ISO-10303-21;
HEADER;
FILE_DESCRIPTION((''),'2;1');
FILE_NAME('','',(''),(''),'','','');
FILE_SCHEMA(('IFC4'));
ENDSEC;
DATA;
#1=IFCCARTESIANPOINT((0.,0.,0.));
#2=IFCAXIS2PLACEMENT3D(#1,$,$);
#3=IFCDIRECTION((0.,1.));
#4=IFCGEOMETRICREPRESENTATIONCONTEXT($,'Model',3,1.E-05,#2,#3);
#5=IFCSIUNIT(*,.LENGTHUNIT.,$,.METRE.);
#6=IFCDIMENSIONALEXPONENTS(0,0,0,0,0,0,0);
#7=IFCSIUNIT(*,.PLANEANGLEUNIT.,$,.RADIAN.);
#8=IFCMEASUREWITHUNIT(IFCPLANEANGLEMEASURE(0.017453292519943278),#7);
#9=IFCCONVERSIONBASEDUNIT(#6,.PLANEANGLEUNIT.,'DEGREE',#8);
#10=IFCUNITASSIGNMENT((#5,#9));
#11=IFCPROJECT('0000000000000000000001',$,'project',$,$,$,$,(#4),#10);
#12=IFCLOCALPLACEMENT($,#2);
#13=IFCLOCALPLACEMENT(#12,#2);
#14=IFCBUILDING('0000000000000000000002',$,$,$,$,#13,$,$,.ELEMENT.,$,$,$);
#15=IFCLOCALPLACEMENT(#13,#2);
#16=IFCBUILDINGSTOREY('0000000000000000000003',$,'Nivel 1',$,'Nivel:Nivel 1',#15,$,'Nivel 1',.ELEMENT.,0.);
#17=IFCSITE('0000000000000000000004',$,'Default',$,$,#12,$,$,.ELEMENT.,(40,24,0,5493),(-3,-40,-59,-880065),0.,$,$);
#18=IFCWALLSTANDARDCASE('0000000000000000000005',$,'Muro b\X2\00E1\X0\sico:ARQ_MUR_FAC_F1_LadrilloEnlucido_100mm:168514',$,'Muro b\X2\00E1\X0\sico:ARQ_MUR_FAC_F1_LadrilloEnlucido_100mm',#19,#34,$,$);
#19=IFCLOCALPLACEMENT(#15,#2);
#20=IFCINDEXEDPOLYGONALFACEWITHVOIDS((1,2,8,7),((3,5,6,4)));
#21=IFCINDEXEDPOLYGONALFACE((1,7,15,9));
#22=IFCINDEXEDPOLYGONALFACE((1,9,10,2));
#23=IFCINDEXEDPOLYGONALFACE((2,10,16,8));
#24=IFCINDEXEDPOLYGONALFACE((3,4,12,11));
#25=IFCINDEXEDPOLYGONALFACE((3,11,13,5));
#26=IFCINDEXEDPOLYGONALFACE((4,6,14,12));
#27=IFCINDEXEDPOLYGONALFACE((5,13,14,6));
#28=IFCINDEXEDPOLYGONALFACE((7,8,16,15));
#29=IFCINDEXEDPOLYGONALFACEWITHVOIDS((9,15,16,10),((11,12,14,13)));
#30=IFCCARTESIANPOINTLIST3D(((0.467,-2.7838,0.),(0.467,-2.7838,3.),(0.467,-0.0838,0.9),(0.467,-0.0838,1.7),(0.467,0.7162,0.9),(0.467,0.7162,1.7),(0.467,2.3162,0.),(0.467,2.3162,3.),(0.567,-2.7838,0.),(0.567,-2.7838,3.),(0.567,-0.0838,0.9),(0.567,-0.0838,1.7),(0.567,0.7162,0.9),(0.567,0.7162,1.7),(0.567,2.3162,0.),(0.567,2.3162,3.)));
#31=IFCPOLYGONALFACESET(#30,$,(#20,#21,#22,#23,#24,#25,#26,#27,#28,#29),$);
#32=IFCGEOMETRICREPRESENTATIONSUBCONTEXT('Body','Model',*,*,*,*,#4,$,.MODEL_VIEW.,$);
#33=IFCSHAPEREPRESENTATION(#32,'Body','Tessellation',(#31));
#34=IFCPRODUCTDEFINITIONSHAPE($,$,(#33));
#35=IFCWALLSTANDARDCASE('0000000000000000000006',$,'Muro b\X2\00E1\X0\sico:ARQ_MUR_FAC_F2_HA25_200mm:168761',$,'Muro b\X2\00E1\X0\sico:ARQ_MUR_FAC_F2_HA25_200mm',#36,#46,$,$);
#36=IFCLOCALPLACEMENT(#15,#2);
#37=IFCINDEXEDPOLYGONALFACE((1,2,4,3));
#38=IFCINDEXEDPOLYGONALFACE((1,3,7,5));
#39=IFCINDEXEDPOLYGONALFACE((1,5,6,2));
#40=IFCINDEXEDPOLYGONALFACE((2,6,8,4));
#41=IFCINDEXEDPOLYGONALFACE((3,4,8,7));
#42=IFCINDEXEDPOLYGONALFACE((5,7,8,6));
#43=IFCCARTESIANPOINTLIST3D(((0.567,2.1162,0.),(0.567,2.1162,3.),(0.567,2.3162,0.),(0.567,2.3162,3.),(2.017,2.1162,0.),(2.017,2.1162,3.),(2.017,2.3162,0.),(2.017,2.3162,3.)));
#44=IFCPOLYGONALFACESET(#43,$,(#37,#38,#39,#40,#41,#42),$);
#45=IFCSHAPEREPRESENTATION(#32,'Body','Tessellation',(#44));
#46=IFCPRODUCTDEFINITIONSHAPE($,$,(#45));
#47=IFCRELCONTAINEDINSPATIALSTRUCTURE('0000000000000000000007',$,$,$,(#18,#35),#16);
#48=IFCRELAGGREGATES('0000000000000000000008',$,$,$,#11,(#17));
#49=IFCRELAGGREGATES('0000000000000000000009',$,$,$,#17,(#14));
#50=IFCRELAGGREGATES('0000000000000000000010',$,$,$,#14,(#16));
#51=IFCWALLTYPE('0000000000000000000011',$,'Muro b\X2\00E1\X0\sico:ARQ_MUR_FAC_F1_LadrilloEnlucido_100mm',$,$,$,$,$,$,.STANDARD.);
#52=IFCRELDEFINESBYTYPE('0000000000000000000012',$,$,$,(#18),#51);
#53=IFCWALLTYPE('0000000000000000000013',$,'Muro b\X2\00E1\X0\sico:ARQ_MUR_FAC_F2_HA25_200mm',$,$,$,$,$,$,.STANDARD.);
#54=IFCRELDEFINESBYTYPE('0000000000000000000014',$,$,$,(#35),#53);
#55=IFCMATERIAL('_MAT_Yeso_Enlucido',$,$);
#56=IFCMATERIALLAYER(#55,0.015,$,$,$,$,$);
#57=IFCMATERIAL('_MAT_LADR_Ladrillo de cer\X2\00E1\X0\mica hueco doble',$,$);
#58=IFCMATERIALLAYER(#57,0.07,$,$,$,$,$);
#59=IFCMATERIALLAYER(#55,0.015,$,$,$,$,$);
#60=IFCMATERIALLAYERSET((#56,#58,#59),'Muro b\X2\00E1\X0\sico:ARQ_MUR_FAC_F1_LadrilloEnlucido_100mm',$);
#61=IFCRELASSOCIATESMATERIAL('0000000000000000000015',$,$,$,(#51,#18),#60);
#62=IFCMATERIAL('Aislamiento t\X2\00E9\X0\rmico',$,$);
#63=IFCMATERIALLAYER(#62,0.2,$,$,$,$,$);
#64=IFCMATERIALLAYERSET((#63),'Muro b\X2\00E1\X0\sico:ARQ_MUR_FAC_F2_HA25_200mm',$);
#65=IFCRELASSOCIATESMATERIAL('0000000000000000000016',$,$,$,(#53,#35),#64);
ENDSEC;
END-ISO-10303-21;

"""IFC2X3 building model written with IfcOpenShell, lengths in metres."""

from ifc_helpers import new_model, entity, si_unit, converted_unit, direction, frame, frame_2d, origin, place, context, subcontext, project, spatial, rectangle, extrude, material, layer, layer_set, layer_usage, type_object, element, save


model = new_model("IFC2X3")

# Units and contexts
model_context = context("Model", 3, precision=1e-05, world=origin(), true_north=direction((0.0, 1.0)))
body_context = subcontext(model_context, "Body", "Model", "MODEL_VIEW")
ifc_project = project(units=[si_unit("LENGTHUNIT", "METRE"), converted_unit("PLANEANGLEUNIT", "DEGREE", entity("IfcPlaneAngleMeasure", 0.017453292519943278), si_unit("PLANEANGLEUNIT", "RADIAN"), dimensions=[0, 0, 0, 0, 0, 0, 0])], contexts=[model_context])

# Site, building, storey
site_placement = place(None, origin())
site = spatial("IfcSite", under=ifc_project, at=site_placement, Name="Default", CompositionType="ELEMENT", RefLatitude=(40, 24, 0, 5493), RefLongitude=(-3, -40, -59, -880065), RefElevation=0.0)
building_placement = place(site_placement, origin())
building = spatial("IfcBuilding", under=site, at=building_placement, CompositionType="ELEMENT")
storey_placement = place(building_placement, origin())
storey = spatial("IfcBuildingStorey", under=building, at=storey_placement, Name="Nivel 1", ObjectType="Nivel:Nivel 1", LongName="Nivel 1", CompositionType="ELEMENT", Elevation=0.0)

# Wall, opening
ifc_material_1 = material(Name="_MAT_Yeso_Enlucido")
ifc_layer_1 = layer(ifc_material_1, 0.015)
ifc_material_2 = material(Name="_MAT_LADR_Ladrillo de cerámica hueco doble")
ifc_layer_2 = layer(ifc_material_2, 0.07)
ifc_layer_3 = layer(ifc_material_1, 0.015)
ifc_layer_set_1 = layer_set([ifc_layer_1, ifc_layer_2, ifc_layer_3], Name="Muro básico:ARQ_MUR_FAC_F1_LadrilloEnlucido_100mm")
ifc_layer_usage_1 = layer_usage(ifc_layer_set_1, "AXIS2", "NEGATIVE", 0.05)
wall_type_1 = type_object("IfcWallType", Name="Muro básico:ARQ_MUR_FAC_F1_LadrilloEnlucido_100mm", PredefinedType="STANDARD", material=ifc_layer_set_1)
wall_1_placement = place(storey_placement, frame((0.517, -2.7838, 0.0), z_axis=(0.0, 0.0, 1.0), x_axis=(0.0, 1.0, 0.0)))
wall_1 = element("IfcWallStandardCase", 1, at=wall_1_placement, inside=storey, type_object=wall_type_1, material=ifc_layer_usage_1, Name="Muro básico:ARQ_MUR_FAC_F1_LadrilloEnlucido_100mm:168514", ObjectType="Muro básico:ARQ_MUR_FAC_F1_LadrilloEnlucido_100mm", context=body_context, shape_type="SweptSolid", body=[
    extrude(rectangle(XDim=5.1, YDim=0.1, at=frame_2d((2.55, 0.0), x_axis=(-1.0, 0.0))), origin(), (0.0, 0.0, 1.0), 3.0),
])
opening_placement = place(wall_1_placement, frame((2.7, -0.05, 0.9)))
element("IfcOpeningElement", 2, at=opening_placement, cuts=wall_1, ObjectType="Opening", context=body_context, shape_type="SweptSolid", body=[
    extrude(rectangle(XDim=0.8, YDim=0.8, at=frame_2d((0.4, 0.4), x_axis=(1.0, 0.0))), frame((0.0, 0.0, 0.0), z_axis=(0.0, 1.0, 0.0), x_axis=(0.0, 0.0, 1.0)), (0.0, 0.0, 1.0), 0.1),
])

# Wall
ifc_material_3 = material(Name="Aislamiento térmico")
ifc_layer_4 = layer(ifc_material_3, 0.2)
ifc_layer_set_2 = layer_set([ifc_layer_4], Name="Muro básico:ARQ_MUR_FAC_F2_HA25_200mm")
ifc_layer_usage_2 = layer_usage(ifc_layer_set_2, "AXIS2", "NEGATIVE", 0.1)
wall_type_2 = type_object("IfcWallType", Name="Muro básico:ARQ_MUR_FAC_F2_HA25_200mm", PredefinedType="STANDARD", material=ifc_layer_set_2)
wall_2_placement = place(storey_placement, frame((0.567, 2.2162, 0.0)))
element("IfcWallStandardCase", 3, at=wall_2_placement, inside=storey, type_object=wall_type_2, material=ifc_layer_usage_2, Name="Muro básico:ARQ_MUR_FAC_F2_HA25_200mm:168761", ObjectType="Muro básico:ARQ_MUR_FAC_F2_HA25_200mm", context=body_context, shape_type="SweptSolid", body=[
    extrude(rectangle(XDim=1.45, YDim=0.2, at=frame_2d((0.725, 0.0), x_axis=(-1.0, 0.0))), origin(), (0.0, 0.0, 1.0), 3.0),
])

save(model, "model.ifc")
